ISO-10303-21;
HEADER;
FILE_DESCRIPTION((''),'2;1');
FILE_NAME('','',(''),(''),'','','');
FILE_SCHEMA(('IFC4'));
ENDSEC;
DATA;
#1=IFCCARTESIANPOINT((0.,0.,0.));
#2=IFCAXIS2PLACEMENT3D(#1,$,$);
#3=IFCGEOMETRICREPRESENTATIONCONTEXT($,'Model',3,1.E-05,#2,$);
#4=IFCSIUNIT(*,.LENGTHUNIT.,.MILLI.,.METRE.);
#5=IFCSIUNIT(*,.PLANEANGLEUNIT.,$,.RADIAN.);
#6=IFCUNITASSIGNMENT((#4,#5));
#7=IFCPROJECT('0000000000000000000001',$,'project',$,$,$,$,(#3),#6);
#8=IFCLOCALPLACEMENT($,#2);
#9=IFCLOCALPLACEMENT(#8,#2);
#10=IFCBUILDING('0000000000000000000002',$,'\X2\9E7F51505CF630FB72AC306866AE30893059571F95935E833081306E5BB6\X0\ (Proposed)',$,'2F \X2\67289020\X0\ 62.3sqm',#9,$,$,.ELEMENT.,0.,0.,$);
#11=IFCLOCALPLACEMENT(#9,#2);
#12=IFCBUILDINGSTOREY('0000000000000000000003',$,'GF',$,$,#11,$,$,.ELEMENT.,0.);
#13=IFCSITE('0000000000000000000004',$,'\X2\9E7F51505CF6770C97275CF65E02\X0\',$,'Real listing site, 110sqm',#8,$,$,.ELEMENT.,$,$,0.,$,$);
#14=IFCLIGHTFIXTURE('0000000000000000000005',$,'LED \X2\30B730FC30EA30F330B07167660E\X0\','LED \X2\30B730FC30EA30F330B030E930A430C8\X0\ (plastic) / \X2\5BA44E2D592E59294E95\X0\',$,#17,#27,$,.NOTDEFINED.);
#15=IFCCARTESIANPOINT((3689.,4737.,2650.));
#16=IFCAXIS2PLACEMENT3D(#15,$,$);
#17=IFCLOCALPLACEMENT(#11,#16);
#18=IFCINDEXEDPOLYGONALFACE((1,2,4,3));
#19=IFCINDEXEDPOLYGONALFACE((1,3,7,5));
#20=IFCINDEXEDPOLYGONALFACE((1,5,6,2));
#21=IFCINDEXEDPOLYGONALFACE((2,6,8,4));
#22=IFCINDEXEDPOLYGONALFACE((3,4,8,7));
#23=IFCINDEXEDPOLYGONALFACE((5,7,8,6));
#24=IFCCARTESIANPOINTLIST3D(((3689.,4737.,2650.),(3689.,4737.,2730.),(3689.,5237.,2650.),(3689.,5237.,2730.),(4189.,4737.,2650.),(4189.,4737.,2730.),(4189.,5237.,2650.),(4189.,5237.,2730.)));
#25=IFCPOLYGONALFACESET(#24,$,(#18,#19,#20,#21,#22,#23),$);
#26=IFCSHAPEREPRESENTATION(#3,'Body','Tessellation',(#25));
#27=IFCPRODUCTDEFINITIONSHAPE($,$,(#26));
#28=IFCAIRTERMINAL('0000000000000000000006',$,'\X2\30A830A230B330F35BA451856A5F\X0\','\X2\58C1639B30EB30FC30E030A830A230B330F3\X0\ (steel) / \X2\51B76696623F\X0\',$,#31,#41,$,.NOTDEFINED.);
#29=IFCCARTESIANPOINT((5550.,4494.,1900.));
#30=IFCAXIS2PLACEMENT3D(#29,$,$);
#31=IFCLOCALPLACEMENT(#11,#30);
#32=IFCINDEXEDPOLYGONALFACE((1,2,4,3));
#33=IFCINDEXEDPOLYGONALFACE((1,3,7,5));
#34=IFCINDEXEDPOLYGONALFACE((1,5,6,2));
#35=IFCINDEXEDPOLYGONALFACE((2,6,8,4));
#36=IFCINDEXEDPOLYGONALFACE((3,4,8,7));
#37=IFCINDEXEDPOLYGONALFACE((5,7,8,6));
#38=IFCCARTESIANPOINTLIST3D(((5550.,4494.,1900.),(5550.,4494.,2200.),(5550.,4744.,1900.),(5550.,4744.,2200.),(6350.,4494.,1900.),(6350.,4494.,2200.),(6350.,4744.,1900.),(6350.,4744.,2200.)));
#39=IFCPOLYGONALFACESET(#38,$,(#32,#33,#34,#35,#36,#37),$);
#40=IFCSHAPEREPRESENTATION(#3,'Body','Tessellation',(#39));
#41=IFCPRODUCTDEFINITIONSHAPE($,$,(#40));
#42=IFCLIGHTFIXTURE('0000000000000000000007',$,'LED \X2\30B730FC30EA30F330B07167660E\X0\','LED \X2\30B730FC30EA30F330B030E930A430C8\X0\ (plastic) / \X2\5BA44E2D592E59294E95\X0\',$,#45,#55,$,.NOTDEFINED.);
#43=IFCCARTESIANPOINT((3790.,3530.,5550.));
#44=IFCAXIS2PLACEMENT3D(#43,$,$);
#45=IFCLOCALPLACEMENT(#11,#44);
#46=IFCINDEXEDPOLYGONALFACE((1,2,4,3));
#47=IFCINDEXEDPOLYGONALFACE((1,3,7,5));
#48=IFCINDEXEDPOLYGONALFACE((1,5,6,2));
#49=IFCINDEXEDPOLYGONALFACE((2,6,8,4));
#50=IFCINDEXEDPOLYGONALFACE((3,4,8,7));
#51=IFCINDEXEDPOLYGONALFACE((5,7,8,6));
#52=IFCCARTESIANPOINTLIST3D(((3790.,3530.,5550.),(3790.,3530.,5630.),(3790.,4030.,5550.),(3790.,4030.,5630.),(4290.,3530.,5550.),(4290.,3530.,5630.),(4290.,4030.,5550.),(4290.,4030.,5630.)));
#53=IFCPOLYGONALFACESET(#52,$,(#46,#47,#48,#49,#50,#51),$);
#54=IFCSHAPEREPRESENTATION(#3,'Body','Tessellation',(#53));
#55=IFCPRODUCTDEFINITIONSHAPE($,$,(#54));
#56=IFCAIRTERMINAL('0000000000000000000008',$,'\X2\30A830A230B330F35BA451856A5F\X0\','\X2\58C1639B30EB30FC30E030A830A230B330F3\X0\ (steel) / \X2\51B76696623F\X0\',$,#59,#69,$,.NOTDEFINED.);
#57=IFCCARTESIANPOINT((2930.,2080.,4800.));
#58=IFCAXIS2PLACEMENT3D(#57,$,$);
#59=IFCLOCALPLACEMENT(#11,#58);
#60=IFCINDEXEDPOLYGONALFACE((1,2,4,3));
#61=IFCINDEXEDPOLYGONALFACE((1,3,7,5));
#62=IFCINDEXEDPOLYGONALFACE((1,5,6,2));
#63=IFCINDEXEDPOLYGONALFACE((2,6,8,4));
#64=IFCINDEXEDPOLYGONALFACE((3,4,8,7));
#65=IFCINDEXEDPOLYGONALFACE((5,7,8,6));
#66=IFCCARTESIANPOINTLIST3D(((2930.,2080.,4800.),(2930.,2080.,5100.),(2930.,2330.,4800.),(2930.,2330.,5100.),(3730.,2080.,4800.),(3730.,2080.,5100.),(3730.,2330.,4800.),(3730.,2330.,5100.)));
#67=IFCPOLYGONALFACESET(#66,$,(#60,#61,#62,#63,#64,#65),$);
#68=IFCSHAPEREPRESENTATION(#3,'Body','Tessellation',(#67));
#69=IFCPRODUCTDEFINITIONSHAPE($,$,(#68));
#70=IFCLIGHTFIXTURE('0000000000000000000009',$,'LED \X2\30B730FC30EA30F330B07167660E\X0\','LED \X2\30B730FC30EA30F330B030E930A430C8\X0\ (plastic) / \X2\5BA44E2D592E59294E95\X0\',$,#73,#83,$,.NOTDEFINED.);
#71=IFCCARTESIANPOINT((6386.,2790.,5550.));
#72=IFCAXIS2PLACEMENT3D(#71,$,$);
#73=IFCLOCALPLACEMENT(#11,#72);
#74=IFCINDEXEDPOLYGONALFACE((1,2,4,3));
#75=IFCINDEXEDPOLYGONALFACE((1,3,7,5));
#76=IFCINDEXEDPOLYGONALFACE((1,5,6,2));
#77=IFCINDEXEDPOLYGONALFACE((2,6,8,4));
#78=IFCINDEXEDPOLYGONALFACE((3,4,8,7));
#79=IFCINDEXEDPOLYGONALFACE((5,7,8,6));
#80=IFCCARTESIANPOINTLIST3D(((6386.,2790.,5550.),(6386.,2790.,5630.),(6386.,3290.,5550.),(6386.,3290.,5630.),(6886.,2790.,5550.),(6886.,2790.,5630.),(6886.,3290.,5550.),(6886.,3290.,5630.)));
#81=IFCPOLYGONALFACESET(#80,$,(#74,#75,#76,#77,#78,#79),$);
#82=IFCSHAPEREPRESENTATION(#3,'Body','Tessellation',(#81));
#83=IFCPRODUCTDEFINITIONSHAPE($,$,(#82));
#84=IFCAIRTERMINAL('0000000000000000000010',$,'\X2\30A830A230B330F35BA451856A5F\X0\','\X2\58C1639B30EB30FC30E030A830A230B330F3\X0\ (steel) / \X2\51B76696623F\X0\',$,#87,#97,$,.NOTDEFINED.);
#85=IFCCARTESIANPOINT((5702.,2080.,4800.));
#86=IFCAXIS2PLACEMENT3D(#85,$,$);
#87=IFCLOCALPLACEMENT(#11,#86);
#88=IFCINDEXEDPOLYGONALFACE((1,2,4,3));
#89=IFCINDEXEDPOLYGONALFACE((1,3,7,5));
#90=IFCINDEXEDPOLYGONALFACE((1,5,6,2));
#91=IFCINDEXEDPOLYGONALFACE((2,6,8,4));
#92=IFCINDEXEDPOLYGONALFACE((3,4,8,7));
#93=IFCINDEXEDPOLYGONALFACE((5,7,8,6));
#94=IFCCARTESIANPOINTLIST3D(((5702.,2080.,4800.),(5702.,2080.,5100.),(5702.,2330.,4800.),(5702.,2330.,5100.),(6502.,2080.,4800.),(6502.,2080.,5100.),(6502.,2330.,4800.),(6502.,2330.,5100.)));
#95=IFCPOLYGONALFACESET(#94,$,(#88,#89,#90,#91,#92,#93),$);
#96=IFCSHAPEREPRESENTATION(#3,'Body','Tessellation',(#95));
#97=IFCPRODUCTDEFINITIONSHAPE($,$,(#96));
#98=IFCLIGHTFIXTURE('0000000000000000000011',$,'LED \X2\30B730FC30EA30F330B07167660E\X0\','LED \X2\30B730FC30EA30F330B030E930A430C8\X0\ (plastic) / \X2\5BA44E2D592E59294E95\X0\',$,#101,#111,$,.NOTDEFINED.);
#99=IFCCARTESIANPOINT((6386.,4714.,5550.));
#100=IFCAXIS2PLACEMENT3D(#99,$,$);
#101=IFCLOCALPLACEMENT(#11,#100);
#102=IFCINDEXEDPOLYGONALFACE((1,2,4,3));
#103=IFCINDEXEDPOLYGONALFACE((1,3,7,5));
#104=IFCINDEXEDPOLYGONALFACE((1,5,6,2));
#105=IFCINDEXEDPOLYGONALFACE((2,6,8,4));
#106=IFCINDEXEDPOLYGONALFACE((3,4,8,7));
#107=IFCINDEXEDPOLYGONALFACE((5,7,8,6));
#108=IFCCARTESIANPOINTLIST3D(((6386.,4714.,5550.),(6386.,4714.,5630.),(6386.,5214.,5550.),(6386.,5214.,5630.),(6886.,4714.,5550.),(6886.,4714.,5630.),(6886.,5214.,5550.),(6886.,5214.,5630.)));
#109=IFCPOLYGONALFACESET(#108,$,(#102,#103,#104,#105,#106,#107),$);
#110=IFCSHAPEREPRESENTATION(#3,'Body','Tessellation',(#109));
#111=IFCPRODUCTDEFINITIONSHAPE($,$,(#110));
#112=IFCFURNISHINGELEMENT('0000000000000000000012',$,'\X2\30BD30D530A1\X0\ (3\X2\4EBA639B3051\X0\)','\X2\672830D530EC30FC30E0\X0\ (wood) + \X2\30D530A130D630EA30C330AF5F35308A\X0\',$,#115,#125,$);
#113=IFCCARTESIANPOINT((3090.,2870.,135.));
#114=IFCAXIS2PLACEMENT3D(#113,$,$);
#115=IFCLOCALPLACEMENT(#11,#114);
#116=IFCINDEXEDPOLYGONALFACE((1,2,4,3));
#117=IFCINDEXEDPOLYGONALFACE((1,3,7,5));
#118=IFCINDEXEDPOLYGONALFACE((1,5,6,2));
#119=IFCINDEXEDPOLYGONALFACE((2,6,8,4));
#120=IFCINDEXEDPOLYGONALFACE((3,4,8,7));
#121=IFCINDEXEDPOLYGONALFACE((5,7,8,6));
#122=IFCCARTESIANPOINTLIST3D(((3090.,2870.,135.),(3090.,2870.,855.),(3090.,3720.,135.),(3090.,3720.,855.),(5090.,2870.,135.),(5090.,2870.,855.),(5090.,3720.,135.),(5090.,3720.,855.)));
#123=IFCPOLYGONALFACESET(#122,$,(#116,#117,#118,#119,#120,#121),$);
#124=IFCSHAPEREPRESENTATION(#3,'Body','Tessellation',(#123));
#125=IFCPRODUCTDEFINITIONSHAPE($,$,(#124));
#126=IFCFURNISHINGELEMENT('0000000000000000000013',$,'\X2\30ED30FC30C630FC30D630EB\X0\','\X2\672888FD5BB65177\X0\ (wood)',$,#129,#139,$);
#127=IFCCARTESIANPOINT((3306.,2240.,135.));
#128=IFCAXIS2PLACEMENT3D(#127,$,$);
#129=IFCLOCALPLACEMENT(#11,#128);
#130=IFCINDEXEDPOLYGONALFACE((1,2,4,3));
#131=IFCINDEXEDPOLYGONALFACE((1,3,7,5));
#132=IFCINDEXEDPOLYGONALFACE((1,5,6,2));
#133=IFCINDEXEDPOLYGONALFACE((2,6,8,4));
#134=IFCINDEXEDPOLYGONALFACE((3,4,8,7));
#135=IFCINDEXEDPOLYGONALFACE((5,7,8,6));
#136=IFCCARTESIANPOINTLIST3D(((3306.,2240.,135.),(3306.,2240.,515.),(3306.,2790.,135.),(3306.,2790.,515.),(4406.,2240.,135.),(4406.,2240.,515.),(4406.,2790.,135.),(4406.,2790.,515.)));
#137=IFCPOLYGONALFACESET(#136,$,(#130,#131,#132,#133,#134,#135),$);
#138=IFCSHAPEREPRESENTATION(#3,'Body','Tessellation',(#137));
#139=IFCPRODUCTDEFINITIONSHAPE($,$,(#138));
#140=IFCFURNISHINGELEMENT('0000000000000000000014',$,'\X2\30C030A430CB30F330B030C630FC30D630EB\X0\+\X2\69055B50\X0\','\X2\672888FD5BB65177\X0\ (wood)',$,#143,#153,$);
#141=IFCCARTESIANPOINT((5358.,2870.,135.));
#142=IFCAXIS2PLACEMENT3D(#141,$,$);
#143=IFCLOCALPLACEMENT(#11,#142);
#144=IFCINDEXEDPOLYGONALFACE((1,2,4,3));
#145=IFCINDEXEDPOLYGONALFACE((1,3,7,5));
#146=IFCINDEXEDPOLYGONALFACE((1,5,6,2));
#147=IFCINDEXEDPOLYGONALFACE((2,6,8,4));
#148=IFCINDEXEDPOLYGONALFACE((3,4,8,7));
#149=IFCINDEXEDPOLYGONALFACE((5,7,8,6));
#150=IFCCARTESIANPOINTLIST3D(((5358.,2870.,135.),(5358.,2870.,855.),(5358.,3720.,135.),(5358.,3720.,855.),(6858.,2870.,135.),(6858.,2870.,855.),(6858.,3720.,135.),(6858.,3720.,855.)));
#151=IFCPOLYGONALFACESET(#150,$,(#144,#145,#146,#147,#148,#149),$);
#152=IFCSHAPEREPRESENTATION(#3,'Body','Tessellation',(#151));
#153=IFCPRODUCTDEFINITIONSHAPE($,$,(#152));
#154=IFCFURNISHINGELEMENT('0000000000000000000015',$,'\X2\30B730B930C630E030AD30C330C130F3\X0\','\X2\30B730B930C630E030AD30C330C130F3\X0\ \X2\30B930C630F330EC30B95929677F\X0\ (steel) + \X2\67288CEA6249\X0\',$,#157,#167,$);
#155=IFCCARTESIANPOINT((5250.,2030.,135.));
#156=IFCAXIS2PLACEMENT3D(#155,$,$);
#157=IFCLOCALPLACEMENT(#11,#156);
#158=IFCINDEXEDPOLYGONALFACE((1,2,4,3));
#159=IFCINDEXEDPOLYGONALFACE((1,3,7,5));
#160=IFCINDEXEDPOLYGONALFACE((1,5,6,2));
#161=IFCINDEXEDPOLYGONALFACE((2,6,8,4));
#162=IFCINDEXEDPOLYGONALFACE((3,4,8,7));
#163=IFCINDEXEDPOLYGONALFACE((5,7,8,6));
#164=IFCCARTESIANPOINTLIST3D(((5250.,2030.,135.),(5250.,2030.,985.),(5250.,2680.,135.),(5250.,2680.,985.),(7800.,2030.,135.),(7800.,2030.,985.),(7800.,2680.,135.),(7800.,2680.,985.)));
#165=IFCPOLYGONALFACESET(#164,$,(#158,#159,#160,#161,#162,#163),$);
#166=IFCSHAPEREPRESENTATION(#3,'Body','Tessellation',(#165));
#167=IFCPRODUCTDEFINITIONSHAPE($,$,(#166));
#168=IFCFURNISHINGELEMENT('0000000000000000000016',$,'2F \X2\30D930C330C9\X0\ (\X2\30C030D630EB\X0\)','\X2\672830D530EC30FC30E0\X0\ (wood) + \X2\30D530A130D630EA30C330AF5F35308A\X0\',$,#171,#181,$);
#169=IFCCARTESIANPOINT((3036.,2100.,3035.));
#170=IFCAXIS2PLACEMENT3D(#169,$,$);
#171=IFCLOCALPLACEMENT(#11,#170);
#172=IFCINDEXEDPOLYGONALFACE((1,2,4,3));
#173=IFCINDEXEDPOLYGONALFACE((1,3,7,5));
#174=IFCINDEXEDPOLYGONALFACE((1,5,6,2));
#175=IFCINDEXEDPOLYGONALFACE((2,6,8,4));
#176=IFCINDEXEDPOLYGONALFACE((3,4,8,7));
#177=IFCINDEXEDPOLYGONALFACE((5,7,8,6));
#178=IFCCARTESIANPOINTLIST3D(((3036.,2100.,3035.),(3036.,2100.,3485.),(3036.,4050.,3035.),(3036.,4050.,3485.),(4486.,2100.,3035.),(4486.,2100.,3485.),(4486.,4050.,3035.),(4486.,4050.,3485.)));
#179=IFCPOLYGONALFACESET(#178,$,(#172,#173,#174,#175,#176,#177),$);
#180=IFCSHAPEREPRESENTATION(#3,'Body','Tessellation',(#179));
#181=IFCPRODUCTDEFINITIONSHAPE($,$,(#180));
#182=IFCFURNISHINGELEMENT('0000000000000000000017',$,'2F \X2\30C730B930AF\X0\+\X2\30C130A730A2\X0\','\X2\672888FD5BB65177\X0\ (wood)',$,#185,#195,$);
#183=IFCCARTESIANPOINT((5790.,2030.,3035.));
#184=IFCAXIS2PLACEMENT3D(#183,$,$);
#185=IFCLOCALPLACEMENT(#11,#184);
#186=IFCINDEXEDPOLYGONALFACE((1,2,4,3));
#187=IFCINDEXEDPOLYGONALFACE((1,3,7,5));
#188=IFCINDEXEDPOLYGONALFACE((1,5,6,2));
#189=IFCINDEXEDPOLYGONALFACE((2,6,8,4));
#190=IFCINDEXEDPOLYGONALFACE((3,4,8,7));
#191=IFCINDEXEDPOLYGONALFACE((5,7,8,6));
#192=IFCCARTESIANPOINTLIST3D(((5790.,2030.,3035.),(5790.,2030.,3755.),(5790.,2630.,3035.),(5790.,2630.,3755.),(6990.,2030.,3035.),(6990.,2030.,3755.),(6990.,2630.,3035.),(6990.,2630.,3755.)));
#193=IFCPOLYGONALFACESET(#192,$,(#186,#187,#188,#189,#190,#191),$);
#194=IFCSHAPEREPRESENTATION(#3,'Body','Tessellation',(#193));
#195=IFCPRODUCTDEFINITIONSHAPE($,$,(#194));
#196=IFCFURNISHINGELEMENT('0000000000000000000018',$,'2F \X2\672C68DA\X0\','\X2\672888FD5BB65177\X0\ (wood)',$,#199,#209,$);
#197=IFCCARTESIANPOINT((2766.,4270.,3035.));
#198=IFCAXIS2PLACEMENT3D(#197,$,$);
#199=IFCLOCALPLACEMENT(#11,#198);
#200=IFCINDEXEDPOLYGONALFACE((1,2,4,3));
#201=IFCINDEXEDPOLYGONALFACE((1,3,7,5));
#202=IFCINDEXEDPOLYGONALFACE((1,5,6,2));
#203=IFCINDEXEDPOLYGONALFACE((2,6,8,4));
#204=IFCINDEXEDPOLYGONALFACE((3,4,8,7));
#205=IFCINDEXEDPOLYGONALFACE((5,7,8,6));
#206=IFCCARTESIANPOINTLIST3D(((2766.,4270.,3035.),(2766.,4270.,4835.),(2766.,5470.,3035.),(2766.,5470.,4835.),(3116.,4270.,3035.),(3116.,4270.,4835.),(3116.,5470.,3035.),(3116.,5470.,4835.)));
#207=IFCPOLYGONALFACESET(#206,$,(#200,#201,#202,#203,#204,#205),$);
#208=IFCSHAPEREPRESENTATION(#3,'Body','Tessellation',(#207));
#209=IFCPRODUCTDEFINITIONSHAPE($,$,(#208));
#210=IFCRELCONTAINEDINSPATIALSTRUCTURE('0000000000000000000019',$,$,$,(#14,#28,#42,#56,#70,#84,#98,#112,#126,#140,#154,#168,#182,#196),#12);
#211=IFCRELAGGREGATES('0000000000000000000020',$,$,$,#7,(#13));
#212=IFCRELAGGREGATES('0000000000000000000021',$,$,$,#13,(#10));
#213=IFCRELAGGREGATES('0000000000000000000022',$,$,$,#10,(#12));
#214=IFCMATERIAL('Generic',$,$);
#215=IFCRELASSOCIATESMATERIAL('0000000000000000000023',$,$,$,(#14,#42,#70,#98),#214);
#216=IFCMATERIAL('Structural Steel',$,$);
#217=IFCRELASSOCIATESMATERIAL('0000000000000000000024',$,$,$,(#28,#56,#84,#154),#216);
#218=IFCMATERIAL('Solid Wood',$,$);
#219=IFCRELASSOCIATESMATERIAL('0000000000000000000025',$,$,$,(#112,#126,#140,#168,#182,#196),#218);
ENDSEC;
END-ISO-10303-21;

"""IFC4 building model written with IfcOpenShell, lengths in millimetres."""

from ifc_helpers import new_model, si_unit, frame, frame_2d, origin, place, context, project, spatial, rectangle, extrude, material, element, save


model = new_model("IFC4")

# Units and contexts
model_context = context("Model", 3, precision=1e-05, world=origin())
ifc_project = project(units=[si_unit("LENGTHUNIT", "METRE", prefix="MILLI"), si_unit("PLANEANGLEUNIT", "RADIAN")], contexts=[model_context])

# Site, building, storey
site_placement = place(None, origin())
site = spatial("IfcSite", under=ifc_project, at=site_placement, Name="鹿児島県霧島市", ObjectType="Real listing site, 110sqm", CompositionType="ELEMENT", RefElevation=0.0)
building_placement = place(site_placement, origin())
building = spatial("IfcBuilding", under=site, at=building_placement, Name="鹿児島・犬と暮らす土間広めの家 (Proposed)", ObjectType="2F 木造 62.3sqm", CompositionType="ELEMENT", ElevationOfRefHeight=0.0, ElevationOfTerrain=0.0)
storey_placement = place(building_placement, origin())
storey = spatial("IfcBuildingStorey", under=building, at=storey_placement, Name="GF", CompositionType="ELEMENT", Elevation=0.0)

# Shared definitions
ifc_material_1 = material(Name="Solid Wood")

# Shared definitions
ifc_material_2 = material(Name="Structural Steel")

# Shared definitions
ifc_material_3 = material(Name="Generic")

# Light fixture
light_fixture_1_placement = place(storey_placement, frame((3689.0, 4737.0, 2650.0)))
element("IfcLightFixture", 1, at=light_fixture_1_placement, inside=storey, material=ifc_material_3, Name="LED シーリング照明", Description="LED シーリングライト (plastic) / 室中央天井", PredefinedType="NOTDEFINED", context=model_context, shape_type="SweptSolid", body=[
    extrude(rectangle(XDim=500.0, YDim=500.0, at=frame_2d((250.0, 250.0))), frame((3689.0, 4737.0, 2650.0)), (0.0, 0.0, 1.0), 80.0),
])

# Air terminal
air_terminal_1_placement = place(storey_placement, frame((5550.0, 4494.0, 1900.0)))
element("IfcAirTerminal", 2, at=air_terminal_1_placement, inside=storey, material=ifc_material_2, Name="エアコン室内機", Description="壁掛ルームエアコン (steel) / 冷暖房", PredefinedType="NOTDEFINED", context=model_context, shape_type="SweptSolid", body=[
    extrude(rectangle(XDim=800.0, YDim=250.0, at=frame_2d((400.0, 125.0))), frame((5550.0, 4494.0, 1900.0)), (0.0, 0.0, 1.0), 300.0),
])

# Light fixture
light_fixture_2_placement = place(storey_placement, frame((3790.0, 3530.0, 5550.0)))
element("IfcLightFixture", 3, at=light_fixture_2_placement, inside=storey, material=ifc_material_3, Name="LED シーリング照明", Description="LED シーリングライト (plastic) / 室中央天井", PredefinedType="NOTDEFINED", context=model_context, shape_type="SweptSolid", body=[
    extrude(rectangle(XDim=500.0, YDim=500.0, at=frame_2d((250.0, 250.0))), frame((3790.0, 3530.0, 5550.0)), (0.0, 0.0, 1.0), 80.0),
])

# Air terminal
air_terminal_2_placement = place(storey_placement, frame((2930.0, 2080.0, 4800.0)))
element("IfcAirTerminal", 4, at=air_terminal_2_placement, inside=storey, material=ifc_material_2, Name="エアコン室内機", Description="壁掛ルームエアコン (steel) / 冷暖房", PredefinedType="NOTDEFINED", context=model_context, shape_type="SweptSolid", body=[
    extrude(rectangle(XDim=800.0, YDim=250.0, at=frame_2d((400.0, 125.0))), frame((2930.0, 2080.0, 4800.0)), (0.0, 0.0, 1.0), 300.0),
])

# Light fixture
light_fixture_3_placement = place(storey_placement, frame((6386.0, 2790.0, 5550.0)))
element("IfcLightFixture", 5, at=light_fixture_3_placement, inside=storey, material=ifc_material_3, Name="LED シーリング照明", Description="LED シーリングライト (plastic) / 室中央天井", PredefinedType="NOTDEFINED", context=model_context, shape_type="SweptSolid", body=[
    extrude(rectangle(XDim=500.0, YDim=500.0, at=frame_2d((250.0, 250.0))), frame((6386.0, 2790.0, 5550.0)), (0.0, 0.0, 1.0), 80.0),
])

# Air terminal
air_terminal_3_placement = place(storey_placement, frame((5702.0, 2080.0, 4800.0)))
element("IfcAirTerminal", 6, at=air_terminal_3_placement, inside=storey, material=ifc_material_2, Name="エアコン室内機", Description="壁掛ルームエアコン (steel) / 冷暖房", PredefinedType="NOTDEFINED", context=model_context, shape_type="SweptSolid", body=[
    extrude(rectangle(XDim=800.0, YDim=250.0, at=frame_2d((400.0, 125.0))), frame((5702.0, 2080.0, 4800.0)), (0.0, 0.0, 1.0), 300.0),
])

# Light fixture
light_fixture_4_placement = place(storey_placement, frame((6386.0, 4714.0, 5550.0)))
element("IfcLightFixture", 7, at=light_fixture_4_placement, inside=storey, material=ifc_material_3, Name="LED シーリング照明", Description="LED シーリングライト (plastic) / 室中央天井", PredefinedType="NOTDEFINED", context=model_context, shape_type="SweptSolid", body=[
    extrude(rectangle(XDim=500.0, YDim=500.0, at=frame_2d((250.0, 250.0))), frame((6386.0, 4714.0, 5550.0)), (0.0, 0.0, 1.0), 80.0),
])

# Furnishing elements
furnishing_1_placement = place(storey_placement, frame((3090.0, 2870.0, 135.0)))
element("IfcFurnishingElement", 8, at=furnishing_1_placement, inside=storey, material=ifc_material_1, Name="ソファ (3人掛け)", Description="木フレーム (wood) + ファブリック張り", context=model_context, shape_type="SweptSolid", body=[
    extrude(rectangle(XDim=2000.0, YDim=850.0, at=frame_2d((1000.0, 425.0))), frame((3090.0, 2870.0, 135.0)), (0.0, 0.0, 1.0), 720.0),
])
furnishing_2_placement = place(storey_placement, frame((3306.0, 2240.0, 135.0)))
element("IfcFurnishingElement", 9, at=furnishing_2_placement, inside=storey, material=ifc_material_1, Name="ローテーブル", Description="木製家具 (wood)", context=model_context, shape_type="SweptSolid", body=[
    extrude(rectangle(XDim=1100.0, YDim=550.0, at=frame_2d((550.0, 275.0))), frame((3306.0, 2240.0, 135.0)), (0.0, 0.0, 1.0), 380.0),
])
furnishing_3_placement = place(storey_placement, frame((5358.0, 2870.0, 135.0)))
element("IfcFurnishingElement", 10, at=furnishing_3_placement, inside=storey, material=ifc_material_1, Name="ダイニングテーブル+椅子", Description="木製家具 (wood)", context=model_context, shape_type="SweptSolid", body=[
    extrude(rectangle(XDim=1500.0, YDim=850.0, at=frame_2d((750.0, 425.0))), frame((5358.0, 2870.0, 135.0)), (0.0, 0.0, 1.0), 720.0),
])
furnishing_4_placement = place(storey_placement, frame((5250.0, 2030.0, 135.0)))
element("IfcFurnishingElement", 11, at=furnishing_4_placement, inside=storey, material=ifc_material_2, Name="システムキッチン", Description="システムキッチン ステンレス天板 (steel) + 木質扉", context=model_context, shape_type="SweptSolid", body=[
    extrude(rectangle(XDim=2550.0, YDim=650.0, at=frame_2d((1275.0, 325.0))), frame((5250.0, 2030.0, 135.0)), (0.0, 0.0, 1.0), 850.0),
])
furnishing_5_placement = place(storey_placement, frame((3036.0, 2100.0, 3035.0)))
element("IfcFurnishingElement", 12, at=furnishing_5_placement, inside=storey, material=ifc_material_1, Name="2F ベッド (ダブル)", Description="木フレーム (wood) + ファブリック張り", context=model_context, shape_type="SweptSolid", body=[
    extrude(rectangle(XDim=1450.0, YDim=1950.0, at=frame_2d((725.0, 975.0))), frame((3036.0, 2100.0, 3035.0)), (0.0, 0.0, 1.0), 450.0),
])
furnishing_6_placement = place(storey_placement, frame((5790.0, 2030.0, 3035.0)))
element("IfcFurnishingElement", 13, at=furnishing_6_placement, inside=storey, material=ifc_material_1, Name="2F デスク+チェア", Description="木製家具 (wood)", context=model_context, shape_type="SweptSolid", body=[
    extrude(rectangle(XDim=1200.0, YDim=600.0, at=frame_2d((600.0, 300.0))), frame((5790.0, 2030.0, 3035.0)), (0.0, 0.0, 1.0), 720.0),
])
furnishing_7_placement = place(storey_placement, frame((2766.0, 4270.0, 3035.0)))
element("IfcFurnishingElement", 14, at=furnishing_7_placement, inside=storey, material=ifc_material_1, Name="2F 本棚", Description="木製家具 (wood)", context=model_context, shape_type="SweptSolid", body=[
    extrude(rectangle(XDim=350.0, YDim=1200.0, at=frame_2d((175.0, 600.0))), frame((2766.0, 4270.0, 3035.0)), (0.0, 0.0, 1.0), 1800.0),
])

save(model, "model.ifc")
